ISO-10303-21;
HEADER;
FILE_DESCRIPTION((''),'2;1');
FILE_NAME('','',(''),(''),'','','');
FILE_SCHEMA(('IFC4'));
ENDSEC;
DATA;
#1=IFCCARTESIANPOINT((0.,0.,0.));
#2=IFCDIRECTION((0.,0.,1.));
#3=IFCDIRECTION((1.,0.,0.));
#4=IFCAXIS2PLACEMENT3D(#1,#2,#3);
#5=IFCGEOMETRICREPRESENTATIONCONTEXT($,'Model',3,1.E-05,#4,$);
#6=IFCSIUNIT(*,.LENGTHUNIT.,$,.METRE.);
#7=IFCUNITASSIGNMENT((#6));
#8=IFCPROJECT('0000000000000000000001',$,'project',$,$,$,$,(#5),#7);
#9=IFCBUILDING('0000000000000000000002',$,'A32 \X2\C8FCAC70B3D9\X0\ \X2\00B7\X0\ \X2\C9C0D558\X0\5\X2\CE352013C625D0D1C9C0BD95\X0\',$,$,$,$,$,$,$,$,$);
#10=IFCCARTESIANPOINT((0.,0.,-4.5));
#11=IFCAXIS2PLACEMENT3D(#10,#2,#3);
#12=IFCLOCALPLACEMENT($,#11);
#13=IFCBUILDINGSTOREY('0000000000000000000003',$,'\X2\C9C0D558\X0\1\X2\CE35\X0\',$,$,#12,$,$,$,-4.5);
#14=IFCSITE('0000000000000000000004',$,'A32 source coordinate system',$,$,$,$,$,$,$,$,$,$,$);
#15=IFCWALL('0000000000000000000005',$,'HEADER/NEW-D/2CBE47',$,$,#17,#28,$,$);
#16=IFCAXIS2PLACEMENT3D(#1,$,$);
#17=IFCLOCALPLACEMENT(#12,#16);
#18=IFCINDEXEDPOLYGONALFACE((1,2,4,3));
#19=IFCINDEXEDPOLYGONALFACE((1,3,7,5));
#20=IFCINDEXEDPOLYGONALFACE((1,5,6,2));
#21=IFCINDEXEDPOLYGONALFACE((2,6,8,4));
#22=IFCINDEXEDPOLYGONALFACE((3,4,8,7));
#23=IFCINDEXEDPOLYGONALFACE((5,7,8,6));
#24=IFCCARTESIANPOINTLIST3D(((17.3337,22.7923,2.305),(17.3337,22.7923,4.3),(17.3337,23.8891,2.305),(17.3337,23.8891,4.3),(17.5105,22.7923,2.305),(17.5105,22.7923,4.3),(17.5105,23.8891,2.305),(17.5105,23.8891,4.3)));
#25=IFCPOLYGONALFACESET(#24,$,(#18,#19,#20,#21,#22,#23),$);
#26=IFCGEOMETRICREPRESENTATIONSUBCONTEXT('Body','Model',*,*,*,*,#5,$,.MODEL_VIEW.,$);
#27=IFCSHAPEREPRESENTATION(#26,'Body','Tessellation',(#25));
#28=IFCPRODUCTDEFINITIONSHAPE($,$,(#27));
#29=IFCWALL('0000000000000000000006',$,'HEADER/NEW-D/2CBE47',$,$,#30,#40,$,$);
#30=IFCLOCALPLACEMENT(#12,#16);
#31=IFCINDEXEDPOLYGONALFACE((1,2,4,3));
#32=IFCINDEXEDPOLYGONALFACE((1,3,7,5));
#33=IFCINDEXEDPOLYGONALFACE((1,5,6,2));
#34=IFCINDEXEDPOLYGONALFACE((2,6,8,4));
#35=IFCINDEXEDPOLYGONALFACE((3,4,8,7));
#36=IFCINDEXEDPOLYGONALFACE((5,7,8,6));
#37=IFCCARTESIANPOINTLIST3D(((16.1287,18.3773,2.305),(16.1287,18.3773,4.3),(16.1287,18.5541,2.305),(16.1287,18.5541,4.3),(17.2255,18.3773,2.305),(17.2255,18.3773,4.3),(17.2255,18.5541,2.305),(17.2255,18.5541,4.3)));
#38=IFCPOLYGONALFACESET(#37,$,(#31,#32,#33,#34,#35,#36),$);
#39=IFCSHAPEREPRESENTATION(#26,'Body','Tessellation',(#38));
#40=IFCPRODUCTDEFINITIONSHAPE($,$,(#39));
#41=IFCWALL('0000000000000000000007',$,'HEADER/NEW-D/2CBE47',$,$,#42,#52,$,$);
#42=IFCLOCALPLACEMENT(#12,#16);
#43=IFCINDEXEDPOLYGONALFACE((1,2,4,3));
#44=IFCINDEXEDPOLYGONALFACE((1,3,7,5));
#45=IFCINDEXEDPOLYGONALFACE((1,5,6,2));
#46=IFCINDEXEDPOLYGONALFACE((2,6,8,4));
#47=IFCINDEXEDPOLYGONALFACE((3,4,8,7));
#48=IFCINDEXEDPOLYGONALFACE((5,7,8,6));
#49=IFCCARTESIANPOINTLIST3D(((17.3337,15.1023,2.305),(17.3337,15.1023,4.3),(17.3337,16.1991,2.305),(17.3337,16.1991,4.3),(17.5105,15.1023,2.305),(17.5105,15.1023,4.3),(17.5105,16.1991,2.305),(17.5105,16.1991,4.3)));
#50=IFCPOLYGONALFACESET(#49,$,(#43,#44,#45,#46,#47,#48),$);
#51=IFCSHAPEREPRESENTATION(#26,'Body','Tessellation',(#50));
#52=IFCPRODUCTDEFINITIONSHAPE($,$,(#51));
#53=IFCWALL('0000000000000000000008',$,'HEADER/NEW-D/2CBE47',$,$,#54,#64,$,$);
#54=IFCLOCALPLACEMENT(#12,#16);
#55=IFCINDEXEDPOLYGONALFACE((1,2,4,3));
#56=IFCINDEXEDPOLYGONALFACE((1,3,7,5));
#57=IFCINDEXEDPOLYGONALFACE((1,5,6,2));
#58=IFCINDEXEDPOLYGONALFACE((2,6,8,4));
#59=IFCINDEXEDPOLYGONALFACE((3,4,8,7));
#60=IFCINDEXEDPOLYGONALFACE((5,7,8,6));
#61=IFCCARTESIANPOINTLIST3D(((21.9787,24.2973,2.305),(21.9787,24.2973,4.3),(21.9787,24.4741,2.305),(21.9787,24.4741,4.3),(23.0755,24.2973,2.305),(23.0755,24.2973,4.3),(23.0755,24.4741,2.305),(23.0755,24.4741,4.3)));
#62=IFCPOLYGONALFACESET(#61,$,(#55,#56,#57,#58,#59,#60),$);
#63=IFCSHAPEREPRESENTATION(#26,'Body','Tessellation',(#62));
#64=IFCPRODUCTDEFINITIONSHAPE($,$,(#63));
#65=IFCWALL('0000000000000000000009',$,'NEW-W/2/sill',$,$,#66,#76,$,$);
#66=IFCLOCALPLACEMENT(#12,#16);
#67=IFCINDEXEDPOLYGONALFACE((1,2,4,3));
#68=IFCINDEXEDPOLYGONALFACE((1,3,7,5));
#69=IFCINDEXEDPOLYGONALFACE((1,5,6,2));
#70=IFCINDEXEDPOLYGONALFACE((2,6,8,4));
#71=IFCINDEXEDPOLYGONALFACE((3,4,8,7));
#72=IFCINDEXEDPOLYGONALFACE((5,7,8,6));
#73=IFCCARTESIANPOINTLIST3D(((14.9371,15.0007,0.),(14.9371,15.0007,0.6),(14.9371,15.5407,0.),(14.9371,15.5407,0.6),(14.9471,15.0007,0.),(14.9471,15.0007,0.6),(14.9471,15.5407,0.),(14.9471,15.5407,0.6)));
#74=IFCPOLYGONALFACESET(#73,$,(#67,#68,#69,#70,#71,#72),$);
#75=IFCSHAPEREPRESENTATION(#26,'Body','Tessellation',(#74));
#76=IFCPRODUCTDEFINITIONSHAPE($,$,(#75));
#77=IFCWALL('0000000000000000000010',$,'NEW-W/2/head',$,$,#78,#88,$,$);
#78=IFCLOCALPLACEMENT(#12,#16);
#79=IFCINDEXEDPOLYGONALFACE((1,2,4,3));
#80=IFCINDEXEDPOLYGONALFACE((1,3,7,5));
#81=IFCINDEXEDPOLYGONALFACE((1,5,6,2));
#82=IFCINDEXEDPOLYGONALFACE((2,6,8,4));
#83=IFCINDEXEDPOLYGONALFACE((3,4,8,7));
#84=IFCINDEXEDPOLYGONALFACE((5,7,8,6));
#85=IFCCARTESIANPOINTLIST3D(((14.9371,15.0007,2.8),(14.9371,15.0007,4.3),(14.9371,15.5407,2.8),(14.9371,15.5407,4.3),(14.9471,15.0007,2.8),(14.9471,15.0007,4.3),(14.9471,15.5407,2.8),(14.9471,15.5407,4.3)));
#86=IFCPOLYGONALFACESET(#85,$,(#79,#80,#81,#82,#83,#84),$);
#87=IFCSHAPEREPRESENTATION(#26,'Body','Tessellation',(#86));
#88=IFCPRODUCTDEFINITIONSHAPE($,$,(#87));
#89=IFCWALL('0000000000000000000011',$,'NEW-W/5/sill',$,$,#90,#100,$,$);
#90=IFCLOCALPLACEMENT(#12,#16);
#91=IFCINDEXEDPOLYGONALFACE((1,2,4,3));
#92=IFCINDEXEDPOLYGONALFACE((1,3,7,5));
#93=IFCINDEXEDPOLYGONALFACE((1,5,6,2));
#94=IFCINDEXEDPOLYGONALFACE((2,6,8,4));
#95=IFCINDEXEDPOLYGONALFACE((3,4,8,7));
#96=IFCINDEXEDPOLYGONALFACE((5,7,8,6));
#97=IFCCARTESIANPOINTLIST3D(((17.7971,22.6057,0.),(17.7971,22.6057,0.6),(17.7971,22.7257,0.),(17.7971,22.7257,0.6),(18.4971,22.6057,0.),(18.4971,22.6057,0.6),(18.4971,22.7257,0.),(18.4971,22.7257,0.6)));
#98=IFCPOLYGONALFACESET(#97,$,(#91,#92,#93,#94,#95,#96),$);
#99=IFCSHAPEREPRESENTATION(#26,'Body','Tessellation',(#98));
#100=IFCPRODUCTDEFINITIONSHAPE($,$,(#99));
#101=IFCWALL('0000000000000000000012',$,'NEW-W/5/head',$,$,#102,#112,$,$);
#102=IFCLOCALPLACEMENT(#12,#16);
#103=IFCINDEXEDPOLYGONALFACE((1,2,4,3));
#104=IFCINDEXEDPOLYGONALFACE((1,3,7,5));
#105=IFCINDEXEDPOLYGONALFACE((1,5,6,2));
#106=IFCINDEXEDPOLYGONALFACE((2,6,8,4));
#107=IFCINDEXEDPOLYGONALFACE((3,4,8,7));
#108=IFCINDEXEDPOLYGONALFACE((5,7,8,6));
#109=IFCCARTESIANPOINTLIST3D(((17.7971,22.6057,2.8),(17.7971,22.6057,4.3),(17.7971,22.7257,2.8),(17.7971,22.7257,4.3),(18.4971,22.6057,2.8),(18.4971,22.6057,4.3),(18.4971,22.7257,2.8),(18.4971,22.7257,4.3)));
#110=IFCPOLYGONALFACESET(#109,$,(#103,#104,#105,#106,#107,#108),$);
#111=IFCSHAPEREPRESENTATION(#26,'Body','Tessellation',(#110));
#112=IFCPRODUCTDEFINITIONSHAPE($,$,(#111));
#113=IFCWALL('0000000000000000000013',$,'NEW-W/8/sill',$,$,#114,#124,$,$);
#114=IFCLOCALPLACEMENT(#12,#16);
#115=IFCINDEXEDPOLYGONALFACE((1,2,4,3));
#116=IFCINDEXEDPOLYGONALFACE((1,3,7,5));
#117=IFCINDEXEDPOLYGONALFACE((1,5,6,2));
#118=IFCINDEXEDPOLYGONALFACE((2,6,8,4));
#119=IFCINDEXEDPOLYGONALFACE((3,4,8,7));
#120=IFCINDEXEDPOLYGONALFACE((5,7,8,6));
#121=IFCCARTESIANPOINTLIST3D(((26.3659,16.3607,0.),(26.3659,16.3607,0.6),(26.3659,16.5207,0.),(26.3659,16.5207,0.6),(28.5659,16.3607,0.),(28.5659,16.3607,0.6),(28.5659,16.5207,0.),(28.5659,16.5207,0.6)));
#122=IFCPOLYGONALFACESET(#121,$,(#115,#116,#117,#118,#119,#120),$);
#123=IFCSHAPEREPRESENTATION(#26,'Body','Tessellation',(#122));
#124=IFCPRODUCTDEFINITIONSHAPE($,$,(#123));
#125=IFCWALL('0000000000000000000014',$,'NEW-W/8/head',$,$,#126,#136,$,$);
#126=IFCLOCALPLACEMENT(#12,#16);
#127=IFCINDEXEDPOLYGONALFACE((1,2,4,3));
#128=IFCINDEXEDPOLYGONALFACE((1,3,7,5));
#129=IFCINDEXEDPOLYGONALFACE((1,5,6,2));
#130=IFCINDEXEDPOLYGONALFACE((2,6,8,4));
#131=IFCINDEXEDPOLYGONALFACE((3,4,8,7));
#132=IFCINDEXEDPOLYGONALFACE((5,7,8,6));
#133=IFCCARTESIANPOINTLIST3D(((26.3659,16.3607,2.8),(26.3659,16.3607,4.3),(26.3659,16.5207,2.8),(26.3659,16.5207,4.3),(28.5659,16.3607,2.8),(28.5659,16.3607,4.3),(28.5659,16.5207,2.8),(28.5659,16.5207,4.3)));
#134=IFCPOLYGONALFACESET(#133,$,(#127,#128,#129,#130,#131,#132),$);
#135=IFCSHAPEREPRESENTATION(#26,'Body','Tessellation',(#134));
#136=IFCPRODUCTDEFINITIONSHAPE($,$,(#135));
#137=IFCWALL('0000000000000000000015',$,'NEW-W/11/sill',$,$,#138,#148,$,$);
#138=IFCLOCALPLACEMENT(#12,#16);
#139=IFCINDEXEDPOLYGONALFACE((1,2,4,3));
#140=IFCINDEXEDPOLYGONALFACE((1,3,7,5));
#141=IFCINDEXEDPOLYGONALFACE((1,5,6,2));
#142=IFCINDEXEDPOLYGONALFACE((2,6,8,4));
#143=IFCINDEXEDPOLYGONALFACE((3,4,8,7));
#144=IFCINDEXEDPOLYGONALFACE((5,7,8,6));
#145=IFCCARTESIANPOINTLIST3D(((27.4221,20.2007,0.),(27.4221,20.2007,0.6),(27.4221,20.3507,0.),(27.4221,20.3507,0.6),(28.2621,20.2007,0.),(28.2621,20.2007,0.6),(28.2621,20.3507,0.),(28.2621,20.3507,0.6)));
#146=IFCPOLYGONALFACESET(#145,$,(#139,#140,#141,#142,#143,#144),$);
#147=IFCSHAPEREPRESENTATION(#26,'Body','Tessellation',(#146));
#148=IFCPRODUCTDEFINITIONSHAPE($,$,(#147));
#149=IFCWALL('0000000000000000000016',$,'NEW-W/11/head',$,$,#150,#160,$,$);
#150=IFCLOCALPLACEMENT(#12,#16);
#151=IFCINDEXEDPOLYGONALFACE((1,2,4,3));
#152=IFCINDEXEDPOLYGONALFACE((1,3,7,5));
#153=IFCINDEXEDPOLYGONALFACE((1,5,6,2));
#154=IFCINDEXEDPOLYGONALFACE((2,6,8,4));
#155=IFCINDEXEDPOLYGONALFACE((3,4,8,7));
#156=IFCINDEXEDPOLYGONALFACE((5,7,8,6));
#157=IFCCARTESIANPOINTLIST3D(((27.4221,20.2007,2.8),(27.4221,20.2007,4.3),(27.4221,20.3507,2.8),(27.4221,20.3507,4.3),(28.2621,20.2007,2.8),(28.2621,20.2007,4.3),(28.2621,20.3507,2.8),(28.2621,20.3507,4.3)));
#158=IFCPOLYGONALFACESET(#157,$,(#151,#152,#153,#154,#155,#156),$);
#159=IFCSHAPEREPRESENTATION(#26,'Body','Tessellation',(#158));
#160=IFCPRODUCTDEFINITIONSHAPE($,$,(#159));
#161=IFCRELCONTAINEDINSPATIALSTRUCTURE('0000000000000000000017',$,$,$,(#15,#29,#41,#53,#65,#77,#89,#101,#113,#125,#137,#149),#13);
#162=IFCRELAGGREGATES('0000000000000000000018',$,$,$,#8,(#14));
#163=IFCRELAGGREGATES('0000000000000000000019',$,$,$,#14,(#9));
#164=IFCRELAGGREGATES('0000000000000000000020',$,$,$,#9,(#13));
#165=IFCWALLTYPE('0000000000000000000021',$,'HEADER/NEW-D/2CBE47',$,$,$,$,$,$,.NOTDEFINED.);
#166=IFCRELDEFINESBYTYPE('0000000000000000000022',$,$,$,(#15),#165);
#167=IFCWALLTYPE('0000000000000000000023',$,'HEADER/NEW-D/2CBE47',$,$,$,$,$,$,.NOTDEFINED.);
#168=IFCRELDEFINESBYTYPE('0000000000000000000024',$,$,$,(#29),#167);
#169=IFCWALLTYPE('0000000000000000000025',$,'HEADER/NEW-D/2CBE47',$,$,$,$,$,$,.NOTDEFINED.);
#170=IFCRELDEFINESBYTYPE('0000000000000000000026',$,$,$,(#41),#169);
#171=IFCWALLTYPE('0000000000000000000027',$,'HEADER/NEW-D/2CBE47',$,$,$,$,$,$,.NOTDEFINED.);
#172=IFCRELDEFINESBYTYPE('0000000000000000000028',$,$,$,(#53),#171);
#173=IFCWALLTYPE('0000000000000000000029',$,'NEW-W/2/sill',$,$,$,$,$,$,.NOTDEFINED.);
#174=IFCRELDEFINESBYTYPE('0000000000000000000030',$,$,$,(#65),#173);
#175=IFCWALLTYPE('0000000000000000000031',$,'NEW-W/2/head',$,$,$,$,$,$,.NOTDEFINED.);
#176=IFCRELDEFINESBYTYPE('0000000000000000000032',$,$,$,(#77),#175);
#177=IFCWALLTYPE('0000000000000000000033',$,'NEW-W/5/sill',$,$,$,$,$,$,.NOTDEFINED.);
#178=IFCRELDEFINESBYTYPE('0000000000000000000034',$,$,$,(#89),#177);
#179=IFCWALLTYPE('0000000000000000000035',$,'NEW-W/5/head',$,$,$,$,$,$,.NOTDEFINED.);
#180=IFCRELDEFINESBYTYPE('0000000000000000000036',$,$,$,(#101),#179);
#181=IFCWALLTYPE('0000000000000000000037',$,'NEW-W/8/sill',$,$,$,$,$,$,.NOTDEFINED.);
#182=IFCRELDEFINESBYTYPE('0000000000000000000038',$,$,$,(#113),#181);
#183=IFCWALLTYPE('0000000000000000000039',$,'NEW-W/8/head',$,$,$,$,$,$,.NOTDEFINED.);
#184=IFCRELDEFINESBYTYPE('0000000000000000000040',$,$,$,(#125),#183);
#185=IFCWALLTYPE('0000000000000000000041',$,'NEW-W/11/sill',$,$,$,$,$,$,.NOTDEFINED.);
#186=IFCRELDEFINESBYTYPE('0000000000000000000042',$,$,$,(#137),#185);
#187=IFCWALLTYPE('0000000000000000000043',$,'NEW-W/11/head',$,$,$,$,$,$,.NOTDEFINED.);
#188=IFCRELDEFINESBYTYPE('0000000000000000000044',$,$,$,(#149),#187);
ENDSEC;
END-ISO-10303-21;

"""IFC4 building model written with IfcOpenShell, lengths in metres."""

from ifc_helpers import new_model, si_unit, frame, origin, origin_with_axes, place, context, subcontext, project, spatial, polyline, outline, extrude, source, transform, mapped, type_object, type_shapes, element, save


model = new_model("IFC4")

# Units and contexts
model_context = context("Model", 3, precision=1e-05, world=origin_with_axes())
body_context = subcontext(model_context, "Body", "Model", "MODEL_VIEW")
ifc_project = project(units=[si_unit("LENGTHUNIT", "METRE")], contexts=[model_context])

# Site, building, storey
site = spatial("IfcSite", under=ifc_project, Name="A32 source coordinate system")
building = spatial("IfcBuilding", under=site, Name="A32 주거동 · 지하5층–옥탑지붕")
storey_placement = place(None, frame((0.0, 0.0, -4.5), z_axis=(0.0, 0.0, 1.0), x_axis=(1.0, 0.0, 0.0)))
storey = spatial("IfcBuildingStorey", under=building, at=storey_placement, Name="지하1층", Elevation=-4.5)

# Walls
wall_type_1 = type_object("IfcWallType", Name="HEADER/NEW-D/2CBE47", PredefinedType="NOTDEFINED")
shared_shape_1 = source(origin(), body_context, "Body", "SweptSolid", [
    extrude(outline(polyline([(17.3337, 22.7923), (17.3337, 23.8891), (17.5105, 23.8891), (17.5105, 22.7923), (17.3337, 22.7923)])), frame((0.0, 0.0, 2.305)), (0.0, 0.0, 1.0), 1.995),
])
type_shapes(wall_type_1, [shared_shape_1])
wall_1_placement = place(storey_placement, origin_with_axes())
element("IfcWall", 1, at=wall_1_placement, inside=storey, type_object=wall_type_1, Name="HEADER/NEW-D/2CBE47", context=body_context, shape_type="MappedRepresentation", body=[
    mapped(shared_shape_1, transform((0.0, 0.0, 0.0), scale=1.0)),
])
wall_type_2 = type_object("IfcWallType", Name="HEADER/NEW-D/2CBE47", PredefinedType="NOTDEFINED")
shared_shape_2 = source(origin(), body_context, "Body", "SweptSolid", [
    extrude(outline(polyline([(16.1287, 18.3773), (16.1287, 18.5541), (17.2255, 18.5541), (17.2255, 18.3773), (16.1287, 18.3773)])), frame((0.0, 0.0, 2.305)), (0.0, 0.0, 1.0), 1.995),
])
type_shapes(wall_type_2, [shared_shape_2])
wall_2_placement = place(storey_placement, origin_with_axes())
element("IfcWall", 2, at=wall_2_placement, inside=storey, type_object=wall_type_2, Name="HEADER/NEW-D/2CBE47", context=body_context, shape_type="MappedRepresentation", body=[
    mapped(shared_shape_2, transform((0.0, 0.0, 0.0), scale=1.0)),
])
wall_type_3 = type_object("IfcWallType", Name="HEADER/NEW-D/2CBE47", PredefinedType="NOTDEFINED")
shared_shape_3 = source(origin(), body_context, "Body", "SweptSolid", [
    extrude(outline(polyline([(17.3337, 15.1023), (17.3337, 16.1991), (17.5105, 16.1991), (17.5105, 15.1023), (17.3337, 15.1023)])), frame((0.0, 0.0, 2.305)), (0.0, 0.0, 1.0), 1.995),
])
type_shapes(wall_type_3, [shared_shape_3])
wall_3_placement = place(storey_placement, origin_with_axes())
element("IfcWall", 3, at=wall_3_placement, inside=storey, type_object=wall_type_3, Name="HEADER/NEW-D/2CBE47", context=body_context, shape_type="MappedRepresentation", body=[
    mapped(shared_shape_3, transform((0.0, 0.0, 0.0), scale=1.0)),
])
wall_type_4 = type_object("IfcWallType", Name="HEADER/NEW-D/2CBE47", PredefinedType="NOTDEFINED")
shared_shape_4 = source(origin(), body_context, "Body", "SweptSolid", [
    extrude(outline(polyline([(21.9787, 24.2973), (21.9787, 24.4741), (23.0755, 24.4741), (23.0755, 24.2973), (21.9787, 24.2973)])), frame((0.0, 0.0, 2.305)), (0.0, 0.0, 1.0), 1.995),
])
type_shapes(wall_type_4, [shared_shape_4])
wall_4_placement = place(storey_placement, origin_with_axes())
element("IfcWall", 4, at=wall_4_placement, inside=storey, type_object=wall_type_4, Name="HEADER/NEW-D/2CBE47", context=body_context, shape_type="MappedRepresentation", body=[
    mapped(shared_shape_4, transform((0.0, 0.0, 0.0), scale=1.0)),
])
wall_type_5 = type_object("IfcWallType", Name="NEW-W/2/sill", PredefinedType="NOTDEFINED")
shared_shape_5 = source(origin(), body_context, "Body", "SweptSolid", [
    extrude(outline(polyline([(14.9471, 15.5407), (14.9471, 15.0007), (14.9371, 15.0007), (14.9371, 15.5407), (14.9471, 15.5407)])), origin(), (0.0, 0.0, 1.0), 0.6),
])
type_shapes(wall_type_5, [shared_shape_5])
wall_5_placement = place(storey_placement, origin_with_axes())
element("IfcWall", 5, at=wall_5_placement, inside=storey, type_object=wall_type_5, Name="NEW-W/2/sill", context=body_context, shape_type="MappedRepresentation", body=[
    mapped(shared_shape_5, transform((0.0, 0.0, 0.0), scale=1.0)),
])
wall_type_6 = type_object("IfcWallType", Name="NEW-W/2/head", PredefinedType="NOTDEFINED")
shared_shape_6 = source(origin(), body_context, "Body", "SweptSolid", [
    extrude(outline(polyline([(14.9471, 15.5407), (14.9471, 15.0007), (14.9371, 15.0007), (14.9371, 15.5407), (14.9471, 15.5407)])), frame((0.0, 0.0, 2.8)), (0.0, 0.0, 1.0), 1.5),
])
type_shapes(wall_type_6, [shared_shape_6])
wall_6_placement = place(storey_placement, origin_with_axes())
element("IfcWall", 6, at=wall_6_placement, inside=storey, type_object=wall_type_6, Name="NEW-W/2/head", context=body_context, shape_type="MappedRepresentation", body=[
    mapped(shared_shape_6, transform((0.0, 0.0, 0.0), scale=1.0)),
])
wall_type_7 = type_object("IfcWallType", Name="NEW-W/5/sill", PredefinedType="NOTDEFINED")
shared_shape_7 = source(origin(), body_context, "Body", "SweptSolid", [
    extrude(outline(polyline([(17.7971, 22.6057), (17.7971, 22.7257), (18.4971, 22.7257), (18.4971, 22.6057), (17.7971, 22.6057)])), origin(), (0.0, 0.0, 1.0), 0.6),
])
type_shapes(wall_type_7, [shared_shape_7])
wall_7_placement = place(storey_placement, origin_with_axes())
element("IfcWall", 7, at=wall_7_placement, inside=storey, type_object=wall_type_7, Name="NEW-W/5/sill", context=body_context, shape_type="MappedRepresentation", body=[
    mapped(shared_shape_7, transform((0.0, 0.0, 0.0), scale=1.0)),
])
wall_type_8 = type_object("IfcWallType", Name="NEW-W/5/head", PredefinedType="NOTDEFINED")
shared_shape_8 = source(origin(), body_context, "Body", "SweptSolid", [
    extrude(outline(polyline([(17.7971, 22.6057), (17.7971, 22.7257), (18.4971, 22.7257), (18.4971, 22.6057), (17.7971, 22.6057)])), frame((0.0, 0.0, 2.8)), (0.0, 0.0, 1.0), 1.5),
])
type_shapes(wall_type_8, [shared_shape_8])
wall_8_placement = place(storey_placement, origin_with_axes())
element("IfcWall", 8, at=wall_8_placement, inside=storey, type_object=wall_type_8, Name="NEW-W/5/head", context=body_context, shape_type="MappedRepresentation", body=[
    mapped(shared_shape_8, transform((0.0, 0.0, 0.0), scale=1.0)),
])
wall_type_9 = type_object("IfcWallType", Name="NEW-W/8/sill", PredefinedType="NOTDEFINED")
shared_shape_9 = source(origin(), body_context, "Body", "SweptSolid", [
    extrude(outline(polyline([(26.3659, 16.3607), (26.3659, 16.5207), (28.5659, 16.5207), (28.5659, 16.3607), (26.3659, 16.3607)])), origin(), (0.0, 0.0, 1.0), 0.6),
])
type_shapes(wall_type_9, [shared_shape_9])
wall_9_placement = place(storey_placement, origin_with_axes())
element("IfcWall", 9, at=wall_9_placement, inside=storey, type_object=wall_type_9, Name="NEW-W/8/sill", context=body_context, shape_type="MappedRepresentation", body=[
    mapped(shared_shape_9, transform((0.0, 0.0, 0.0), scale=1.0)),
])
wall_type_10 = type_object("IfcWallType", Name="NEW-W/8/head", PredefinedType="NOTDEFINED")
shared_shape_10 = source(origin(), body_context, "Body", "SweptSolid", [
    extrude(outline(polyline([(26.3659, 16.3607), (26.3659, 16.5207), (28.5659, 16.5207), (28.5659, 16.3607), (26.3659, 16.3607)])), frame((0.0, 0.0, 2.8)), (0.0, 0.0, 1.0), 1.5),
])
type_shapes(wall_type_10, [shared_shape_10])
wall_10_placement = place(storey_placement, origin_with_axes())
element("IfcWall", 10, at=wall_10_placement, inside=storey, type_object=wall_type_10, Name="NEW-W/8/head", context=body_context, shape_type="MappedRepresentation", body=[
    mapped(shared_shape_10, transform((0.0, 0.0, 0.0), scale=1.0)),
])
wall_type_11 = type_object("IfcWallType", Name="NEW-W/11/sill", PredefinedType="NOTDEFINED")
shared_shape_11 = source(origin(), body_context, "Body", "SweptSolid", [
    extrude(outline(polyline([(27.4221, 20.2007), (27.4221, 20.3507), (28.2621, 20.3507), (28.2621, 20.2007), (27.4221, 20.2007)])), origin(), (0.0, 0.0, 1.0), 0.6),
])
type_shapes(wall_type_11, [shared_shape_11])
wall_11_placement = place(storey_placement, origin_with_axes())
element("IfcWall", 11, at=wall_11_placement, inside=storey, type_object=wall_type_11, Name="NEW-W/11/sill", context=body_context, shape_type="MappedRepresentation", body=[
    mapped(shared_shape_11, transform((0.0, 0.0, 0.0), scale=1.0)),
])
wall_type_12 = type_object("IfcWallType", Name="NEW-W/11/head", PredefinedType="NOTDEFINED")
shared_shape_12 = source(origin(), body_context, "Body", "SweptSolid", [
    extrude(outline(polyline([(27.4221, 20.2007), (27.4221, 20.3507), (28.2621, 20.3507), (28.2621, 20.2007), (27.4221, 20.2007)])), frame((0.0, 0.0, 2.8)), (0.0, 0.0, 1.0), 1.5),
])
type_shapes(wall_type_12, [shared_shape_12])
wall_12_placement = place(storey_placement, origin_with_axes())
element("IfcWall", 12, at=wall_12_placement, inside=storey, type_object=wall_type_12, Name="NEW-W/11/head", context=body_context, shape_type="MappedRepresentation", body=[
    mapped(shared_shape_12, transform((0.0, 0.0, 0.0), scale=1.0)),
])

save(model, "model.ifc")
